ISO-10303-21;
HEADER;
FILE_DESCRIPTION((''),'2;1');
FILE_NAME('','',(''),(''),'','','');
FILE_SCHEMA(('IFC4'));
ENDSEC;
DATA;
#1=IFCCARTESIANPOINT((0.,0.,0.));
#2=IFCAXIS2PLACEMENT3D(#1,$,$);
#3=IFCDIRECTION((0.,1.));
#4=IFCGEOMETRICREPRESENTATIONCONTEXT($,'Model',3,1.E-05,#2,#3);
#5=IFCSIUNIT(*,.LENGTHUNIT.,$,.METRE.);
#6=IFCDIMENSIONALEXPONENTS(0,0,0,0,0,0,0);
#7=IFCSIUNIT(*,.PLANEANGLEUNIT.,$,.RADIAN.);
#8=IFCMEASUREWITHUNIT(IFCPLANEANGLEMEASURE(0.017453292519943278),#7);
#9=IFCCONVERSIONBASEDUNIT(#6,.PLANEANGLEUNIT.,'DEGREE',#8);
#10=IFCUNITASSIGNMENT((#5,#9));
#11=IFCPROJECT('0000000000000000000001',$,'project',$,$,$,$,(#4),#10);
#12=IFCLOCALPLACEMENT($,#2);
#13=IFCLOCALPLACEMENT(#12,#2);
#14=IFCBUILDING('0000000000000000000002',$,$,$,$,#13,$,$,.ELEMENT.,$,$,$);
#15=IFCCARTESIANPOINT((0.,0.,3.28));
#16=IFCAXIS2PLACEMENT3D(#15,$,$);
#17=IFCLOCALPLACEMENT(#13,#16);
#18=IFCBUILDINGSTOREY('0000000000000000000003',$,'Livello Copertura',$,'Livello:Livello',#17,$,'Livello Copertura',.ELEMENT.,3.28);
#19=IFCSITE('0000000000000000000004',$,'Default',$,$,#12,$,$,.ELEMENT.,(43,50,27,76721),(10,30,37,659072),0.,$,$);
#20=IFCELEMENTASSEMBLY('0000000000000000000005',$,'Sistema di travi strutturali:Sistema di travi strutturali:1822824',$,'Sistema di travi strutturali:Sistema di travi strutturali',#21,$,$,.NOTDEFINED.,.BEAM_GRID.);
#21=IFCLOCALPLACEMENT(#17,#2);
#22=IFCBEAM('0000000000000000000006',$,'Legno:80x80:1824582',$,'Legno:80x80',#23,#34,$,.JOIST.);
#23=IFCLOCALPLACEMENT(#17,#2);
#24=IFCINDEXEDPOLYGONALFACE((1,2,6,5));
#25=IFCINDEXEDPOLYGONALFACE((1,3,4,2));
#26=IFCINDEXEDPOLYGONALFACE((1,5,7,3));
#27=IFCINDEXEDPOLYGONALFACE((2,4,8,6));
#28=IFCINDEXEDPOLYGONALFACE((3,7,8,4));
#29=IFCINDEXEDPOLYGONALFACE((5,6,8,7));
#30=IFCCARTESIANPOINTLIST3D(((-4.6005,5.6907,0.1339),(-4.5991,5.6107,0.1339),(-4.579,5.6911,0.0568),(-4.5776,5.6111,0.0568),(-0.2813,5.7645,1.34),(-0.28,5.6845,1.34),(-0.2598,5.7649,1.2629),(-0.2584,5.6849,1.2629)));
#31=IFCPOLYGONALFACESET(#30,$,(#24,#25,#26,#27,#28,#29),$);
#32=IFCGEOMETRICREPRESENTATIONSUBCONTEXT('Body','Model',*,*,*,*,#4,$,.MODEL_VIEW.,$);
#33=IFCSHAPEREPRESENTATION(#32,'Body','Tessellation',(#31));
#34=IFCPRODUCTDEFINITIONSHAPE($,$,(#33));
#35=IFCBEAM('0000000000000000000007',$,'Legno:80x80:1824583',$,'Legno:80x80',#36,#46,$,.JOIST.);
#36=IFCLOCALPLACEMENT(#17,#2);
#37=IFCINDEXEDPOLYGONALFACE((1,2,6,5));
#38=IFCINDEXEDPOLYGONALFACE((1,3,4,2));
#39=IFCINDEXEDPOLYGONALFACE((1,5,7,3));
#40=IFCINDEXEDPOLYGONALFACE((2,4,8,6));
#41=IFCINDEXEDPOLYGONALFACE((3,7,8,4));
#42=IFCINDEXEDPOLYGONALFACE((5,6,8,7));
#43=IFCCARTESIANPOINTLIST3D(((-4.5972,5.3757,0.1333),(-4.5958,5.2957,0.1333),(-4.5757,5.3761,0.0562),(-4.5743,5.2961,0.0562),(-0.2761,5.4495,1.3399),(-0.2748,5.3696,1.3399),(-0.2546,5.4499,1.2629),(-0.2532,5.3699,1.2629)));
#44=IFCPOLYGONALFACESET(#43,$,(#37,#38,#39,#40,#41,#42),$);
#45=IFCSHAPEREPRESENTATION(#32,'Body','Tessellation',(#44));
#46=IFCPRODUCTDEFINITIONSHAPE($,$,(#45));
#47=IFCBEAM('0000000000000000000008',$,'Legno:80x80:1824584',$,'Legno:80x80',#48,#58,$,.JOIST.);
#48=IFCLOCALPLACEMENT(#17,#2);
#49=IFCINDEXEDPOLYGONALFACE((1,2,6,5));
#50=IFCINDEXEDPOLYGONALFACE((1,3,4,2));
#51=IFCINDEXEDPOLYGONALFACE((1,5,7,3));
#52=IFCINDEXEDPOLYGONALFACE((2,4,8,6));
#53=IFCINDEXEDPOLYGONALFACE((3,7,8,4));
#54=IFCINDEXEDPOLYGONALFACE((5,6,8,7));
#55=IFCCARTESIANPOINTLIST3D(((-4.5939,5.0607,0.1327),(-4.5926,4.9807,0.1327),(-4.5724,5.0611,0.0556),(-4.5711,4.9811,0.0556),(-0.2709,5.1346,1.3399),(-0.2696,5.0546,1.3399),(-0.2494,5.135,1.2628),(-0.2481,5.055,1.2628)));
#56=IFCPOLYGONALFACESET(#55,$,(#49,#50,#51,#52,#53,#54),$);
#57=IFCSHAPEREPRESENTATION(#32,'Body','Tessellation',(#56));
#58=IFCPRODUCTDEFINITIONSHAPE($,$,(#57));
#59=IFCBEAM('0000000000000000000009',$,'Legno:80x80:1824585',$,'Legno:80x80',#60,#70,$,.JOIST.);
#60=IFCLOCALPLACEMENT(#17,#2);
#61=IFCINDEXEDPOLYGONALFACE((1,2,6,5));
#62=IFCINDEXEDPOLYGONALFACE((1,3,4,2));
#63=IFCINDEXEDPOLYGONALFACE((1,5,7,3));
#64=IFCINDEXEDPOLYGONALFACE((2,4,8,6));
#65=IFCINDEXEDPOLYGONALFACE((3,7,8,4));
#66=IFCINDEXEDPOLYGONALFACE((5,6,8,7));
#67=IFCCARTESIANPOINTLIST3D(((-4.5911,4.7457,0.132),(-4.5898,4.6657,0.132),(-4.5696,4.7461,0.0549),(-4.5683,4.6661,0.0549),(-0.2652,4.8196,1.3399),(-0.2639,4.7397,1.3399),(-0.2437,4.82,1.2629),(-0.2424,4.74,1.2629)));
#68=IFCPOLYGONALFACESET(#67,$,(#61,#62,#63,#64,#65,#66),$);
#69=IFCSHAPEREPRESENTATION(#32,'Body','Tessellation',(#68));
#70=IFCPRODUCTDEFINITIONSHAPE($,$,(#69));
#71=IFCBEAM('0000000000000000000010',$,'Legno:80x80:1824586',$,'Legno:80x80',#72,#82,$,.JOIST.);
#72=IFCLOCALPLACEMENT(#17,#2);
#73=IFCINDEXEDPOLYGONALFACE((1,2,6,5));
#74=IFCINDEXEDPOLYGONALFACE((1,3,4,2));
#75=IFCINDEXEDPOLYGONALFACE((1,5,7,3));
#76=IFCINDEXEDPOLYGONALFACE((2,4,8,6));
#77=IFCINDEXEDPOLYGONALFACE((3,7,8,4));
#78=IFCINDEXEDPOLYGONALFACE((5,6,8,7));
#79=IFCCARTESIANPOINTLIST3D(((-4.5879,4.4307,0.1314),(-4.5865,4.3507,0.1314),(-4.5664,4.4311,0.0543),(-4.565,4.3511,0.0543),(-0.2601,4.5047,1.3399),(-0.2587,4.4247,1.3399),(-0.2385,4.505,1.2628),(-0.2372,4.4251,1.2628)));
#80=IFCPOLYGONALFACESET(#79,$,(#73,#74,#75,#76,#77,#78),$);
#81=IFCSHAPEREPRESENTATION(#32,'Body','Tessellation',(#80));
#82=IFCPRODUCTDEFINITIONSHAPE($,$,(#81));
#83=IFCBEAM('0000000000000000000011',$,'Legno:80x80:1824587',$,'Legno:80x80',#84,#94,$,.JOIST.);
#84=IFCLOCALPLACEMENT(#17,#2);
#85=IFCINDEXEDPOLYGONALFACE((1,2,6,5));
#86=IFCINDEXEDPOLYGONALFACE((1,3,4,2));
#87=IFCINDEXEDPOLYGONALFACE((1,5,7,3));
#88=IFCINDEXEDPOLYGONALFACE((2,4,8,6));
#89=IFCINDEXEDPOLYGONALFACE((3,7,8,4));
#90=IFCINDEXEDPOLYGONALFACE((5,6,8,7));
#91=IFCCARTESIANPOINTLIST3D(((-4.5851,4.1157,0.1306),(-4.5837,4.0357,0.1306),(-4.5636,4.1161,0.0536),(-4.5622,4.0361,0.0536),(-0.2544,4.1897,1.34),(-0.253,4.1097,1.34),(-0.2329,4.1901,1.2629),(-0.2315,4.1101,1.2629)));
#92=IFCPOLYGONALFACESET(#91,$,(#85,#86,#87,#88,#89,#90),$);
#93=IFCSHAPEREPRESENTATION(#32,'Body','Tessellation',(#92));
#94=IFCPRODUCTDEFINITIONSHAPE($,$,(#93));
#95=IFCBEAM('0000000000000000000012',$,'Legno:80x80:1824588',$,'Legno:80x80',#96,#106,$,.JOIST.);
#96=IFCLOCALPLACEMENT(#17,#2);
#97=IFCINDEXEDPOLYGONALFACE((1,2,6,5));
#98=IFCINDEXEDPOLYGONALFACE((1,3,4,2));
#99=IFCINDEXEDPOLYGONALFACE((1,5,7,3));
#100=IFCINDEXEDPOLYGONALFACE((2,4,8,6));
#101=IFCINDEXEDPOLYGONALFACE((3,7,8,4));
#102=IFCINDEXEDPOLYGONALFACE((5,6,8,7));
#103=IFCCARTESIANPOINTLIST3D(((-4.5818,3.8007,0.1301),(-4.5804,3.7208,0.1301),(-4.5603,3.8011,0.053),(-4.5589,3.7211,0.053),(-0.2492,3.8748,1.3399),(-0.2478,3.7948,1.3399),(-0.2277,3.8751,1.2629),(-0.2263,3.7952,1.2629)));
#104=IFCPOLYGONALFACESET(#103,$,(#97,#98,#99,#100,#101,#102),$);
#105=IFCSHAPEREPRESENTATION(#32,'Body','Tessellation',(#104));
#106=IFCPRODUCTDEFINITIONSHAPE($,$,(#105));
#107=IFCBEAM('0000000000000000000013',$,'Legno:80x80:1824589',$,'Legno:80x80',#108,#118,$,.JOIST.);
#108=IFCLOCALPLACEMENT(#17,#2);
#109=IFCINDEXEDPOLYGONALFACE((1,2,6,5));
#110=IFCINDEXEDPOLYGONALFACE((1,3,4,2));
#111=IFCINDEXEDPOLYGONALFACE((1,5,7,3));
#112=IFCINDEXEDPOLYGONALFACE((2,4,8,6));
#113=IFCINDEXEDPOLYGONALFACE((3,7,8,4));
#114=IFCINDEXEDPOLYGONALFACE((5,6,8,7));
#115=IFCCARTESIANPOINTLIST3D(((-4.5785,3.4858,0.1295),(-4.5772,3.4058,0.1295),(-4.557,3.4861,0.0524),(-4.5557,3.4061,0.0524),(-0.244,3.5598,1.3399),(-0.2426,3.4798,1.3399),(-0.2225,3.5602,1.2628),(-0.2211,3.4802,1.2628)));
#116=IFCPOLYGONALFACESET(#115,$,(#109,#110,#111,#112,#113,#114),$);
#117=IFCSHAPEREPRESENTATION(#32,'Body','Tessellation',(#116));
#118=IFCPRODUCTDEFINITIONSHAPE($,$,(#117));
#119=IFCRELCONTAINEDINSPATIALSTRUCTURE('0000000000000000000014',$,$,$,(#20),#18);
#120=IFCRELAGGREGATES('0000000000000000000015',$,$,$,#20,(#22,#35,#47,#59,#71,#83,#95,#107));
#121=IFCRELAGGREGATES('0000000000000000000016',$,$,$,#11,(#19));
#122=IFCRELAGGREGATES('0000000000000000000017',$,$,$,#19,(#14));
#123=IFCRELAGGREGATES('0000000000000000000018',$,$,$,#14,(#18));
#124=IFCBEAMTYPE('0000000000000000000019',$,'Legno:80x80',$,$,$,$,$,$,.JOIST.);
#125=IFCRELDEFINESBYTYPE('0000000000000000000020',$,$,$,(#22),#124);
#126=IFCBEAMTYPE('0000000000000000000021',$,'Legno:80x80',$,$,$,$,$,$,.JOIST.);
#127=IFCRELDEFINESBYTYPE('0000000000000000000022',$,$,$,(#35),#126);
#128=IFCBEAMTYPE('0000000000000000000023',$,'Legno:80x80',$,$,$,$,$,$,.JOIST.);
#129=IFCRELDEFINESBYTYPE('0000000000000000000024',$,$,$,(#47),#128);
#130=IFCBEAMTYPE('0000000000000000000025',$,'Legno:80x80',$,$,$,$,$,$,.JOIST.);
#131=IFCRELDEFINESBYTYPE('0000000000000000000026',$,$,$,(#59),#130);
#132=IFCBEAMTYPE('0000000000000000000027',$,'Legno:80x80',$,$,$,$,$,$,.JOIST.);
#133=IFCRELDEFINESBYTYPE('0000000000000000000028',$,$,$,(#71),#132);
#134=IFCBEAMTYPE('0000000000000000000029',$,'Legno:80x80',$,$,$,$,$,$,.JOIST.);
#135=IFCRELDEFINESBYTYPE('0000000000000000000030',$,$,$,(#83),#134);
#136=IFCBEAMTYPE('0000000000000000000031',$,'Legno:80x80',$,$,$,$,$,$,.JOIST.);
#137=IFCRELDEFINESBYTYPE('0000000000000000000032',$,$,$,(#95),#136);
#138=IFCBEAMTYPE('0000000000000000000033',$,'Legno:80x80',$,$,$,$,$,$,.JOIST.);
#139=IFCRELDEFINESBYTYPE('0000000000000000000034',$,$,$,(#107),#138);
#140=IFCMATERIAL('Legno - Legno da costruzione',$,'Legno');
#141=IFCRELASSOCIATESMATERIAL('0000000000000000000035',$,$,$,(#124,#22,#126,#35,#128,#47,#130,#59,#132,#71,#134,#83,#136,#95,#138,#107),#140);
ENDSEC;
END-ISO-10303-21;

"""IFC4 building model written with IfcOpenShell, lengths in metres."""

from ifc_helpers import new_model, entity, si_unit, converted_unit, direction, frame, origin, place, context, subcontext, project, spatial, indexed_curve, outline, extrude, source, transform, mapped, material, type_object, type_shapes, element, aggregate, save


model = new_model("IFC4")

# Units and contexts
model_context = context("Model", 3, precision=1e-05, world=origin(), true_north=direction((0.0, 1.0)))
body_context = subcontext(model_context, "Body", "Model", "MODEL_VIEW")
ifc_project = project(units=[si_unit("LENGTHUNIT", "METRE"), converted_unit("PLANEANGLEUNIT", "DEGREE", entity("IfcPlaneAngleMeasure", 0.017453292519943278), si_unit("PLANEANGLEUNIT", "RADIAN"), dimensions=[0, 0, 0, 0, 0, 0, 0])], contexts=[model_context])

# Site, building, storey
site_placement = place(None, origin())
site = spatial("IfcSite", under=ifc_project, at=site_placement, Name="Default", CompositionType="ELEMENT", RefLatitude=(43, 50, 27, 76721), RefLongitude=(10, 30, 37, 659072), RefElevation=0.0)
building_placement = place(site_placement, origin())
building = spatial("IfcBuilding", under=site, at=building_placement, CompositionType="ELEMENT")
storey_placement = place(building_placement, frame((0.0, 0.0, 3.28)))
storey = spatial("IfcBuildingStorey", under=building, at=storey_placement, Name="Livello Copertura", ObjectType="Livello:Livello", LongName="Livello Copertura", CompositionType="ELEMENT", Elevation=3.28)

# Shared definitions
ifc_material_1 = material(Name="Legno - Legno da costruzione", Category="Legno")

# Element assembly, beams
assembly_1_placement = place(storey_placement, origin())
assembly_1 = element("IfcElementAssembly", 1, at=assembly_1_placement, inside=storey, Name="Sistema di travi strutturali:Sistema di travi strutturali:1822824", ObjectType="Sistema di travi strutturali:Sistema di travi strutturali", AssemblyPlace="NOTDEFINED", PredefinedType="BEAM_GRID")
beam_type_1 = type_object("IfcBeamType", Name="Legno:80x80", PredefinedType="JOIST", material=ifc_material_1)
shared_shape_1 = source(origin(), body_context, "Body", "SweptSolid", [
    extrude(outline(indexed_curve([(-2.2425, -0.04), (2.2425, -0.04), (2.2425, 0.04), (-2.2425, 0.04), (-2.2425, -0.04)], self_intersect=False)), frame((0.0, 0.0, -0.04), z_axis=(0.0, 0.0, 1.0), x_axis=(-1.0, 0.0, 0.0)), (0.0, 0.0, 1.0), 0.08),
])
type_shapes(beam_type_1, [shared_shape_1])
beam_1_placement = place(assembly_1_placement, frame((-2.4295, 5.6878, 0.6984), z_axis=(-0.268881, -0.004594, 0.963163), x_axis=(0.963022, 0.016456, 0.26892)))
beam_1 = element("IfcBeam", 2, at=beam_1_placement, type_object=beam_type_1, material=ifc_material_1, Name="Legno:80x80:1824582", ObjectType="Legno:80x80", PredefinedType="JOIST", context=body_context, shape_type="MappedRepresentation", body=[
    mapped(shared_shape_1, transform((0.0, 0.0, 0.0), scale=1.0)),
])
beam_type_2 = type_object("IfcBeamType", Name="Legno:80x80", PredefinedType="JOIST", material=ifc_material_1)
shared_shape_2 = source(origin(), body_context, "Body", "SweptSolid", [
    extrude(outline(indexed_curve([(-2.2435, -0.04), (2.2435, -0.04), (2.2435, 0.04), (-2.2435, 0.04), (-2.2435, -0.04)], self_intersect=False)), frame((0.0, 0.0, -0.04), z_axis=(0.0, 0.0, 1.0), x_axis=(-1.0, 0.0, 0.0)), (0.0, 0.0, 1.0), 0.08),
])
type_shapes(beam_type_2, [shared_shape_2])
beam_2_placement = place(assembly_1_placement, frame((-2.4252, 5.3728, 0.6981), z_axis=(-0.268881, -0.004594, 0.963163), x_axis=(0.963022, 0.016456, 0.26892)))
beam_2 = element("IfcBeam", 3, at=beam_2_placement, type_object=beam_type_2, material=ifc_material_1, Name="Legno:80x80:1824583", ObjectType="Legno:80x80", PredefinedType="JOIST", context=body_context, shape_type="MappedRepresentation", body=[
    mapped(shared_shape_2, transform((0.0, 0.0, 0.0), scale=1.0)),
])
beam_type_3 = type_object("IfcBeamType", Name="Legno:80x80", PredefinedType="JOIST", material=ifc_material_1)
shared_shape_3 = source(origin(), body_context, "Body", "SweptSolid", [
    extrude(outline(indexed_curve([(-2.2445, -0.04), (2.2445, -0.04), (2.2445, 0.04), (-2.2445, 0.04), (-2.2445, -0.04)], self_intersect=False)), frame((0.0, 0.0, -0.04), z_axis=(0.0, 0.0, 1.0), x_axis=(-1.0, 0.0, 0.0)), (0.0, 0.0, 1.0), 0.08),
])
type_shapes(beam_type_3, [shared_shape_3])
beam_3_placement = place(assembly_1_placement, frame((-2.421, 5.0578, 0.6977), z_axis=(-0.268881, -0.004594, 0.963163), x_axis=(0.963022, 0.016456, 0.26892)))
beam_3 = element("IfcBeam", 4, at=beam_3_placement, type_object=beam_type_3, material=ifc_material_1, Name="Legno:80x80:1824584", ObjectType="Legno:80x80", PredefinedType="JOIST", context=body_context, shape_type="MappedRepresentation", body=[
    mapped(shared_shape_3, transform((0.0, 0.0, 0.0), scale=1.0)),
])
beam_type_4 = type_object("IfcBeamType", Name="Legno:80x80", PredefinedType="JOIST", material=ifc_material_1)
shared_shape_4 = source(origin(), body_context, "Body", "SweptSolid", [
    extrude(outline(indexed_curve([(-2.246, -0.04), (2.246, -0.04), (2.246, 0.04), (-2.246, 0.04), (-2.246, -0.04)], self_intersect=False)), frame((0.0, 0.0, -0.04), z_axis=(0.0, 0.0, 1.0), x_axis=(-1.0, 0.0, 0.0)), (0.0, 0.0, 1.0), 0.08),
])
type_shapes(beam_type_4, [shared_shape_4])
beam_4_placement = place(assembly_1_placement, frame((-2.4168, 4.7429, 0.6974), z_axis=(-0.268881, -0.004594, 0.963163), x_axis=(0.963022, 0.016456, 0.26892)))
beam_4 = element("IfcBeam", 5, at=beam_4_placement, type_object=beam_type_4, material=ifc_material_1, Name="Legno:80x80:1824585", ObjectType="Legno:80x80", PredefinedType="JOIST", context=body_context, shape_type="MappedRepresentation", body=[
    mapped(shared_shape_4, transform((0.0, 0.0, 0.0), scale=1.0)),
])
beam_type_5 = type_object("IfcBeamType", Name="Legno:80x80", PredefinedType="JOIST", material=ifc_material_1)
shared_shape_5 = source(origin(), body_context, "Body", "SweptSolid", [
    extrude(outline(indexed_curve([(-2.247, -0.04), (2.247, -0.04), (2.247, 0.04), (-2.247, 0.04), (-2.247, -0.04)], self_intersect=False)), frame((0.0, 0.0, -0.04), z_axis=(0.0, 0.0, 1.0), x_axis=(-1.0, 0.0, 0.0)), (0.0, 0.0, 1.0), 0.08),
])
type_shapes(beam_type_5, [shared_shape_5])
beam_5_placement = place(assembly_1_placement, frame((-2.4125, 4.4279, 0.6971), z_axis=(-0.268881, -0.004594, 0.963163), x_axis=(0.963022, 0.016456, 0.26892)))
beam_5 = element("IfcBeam", 6, at=beam_5_placement, type_object=beam_type_5, material=ifc_material_1, Name="Legno:80x80:1824586", ObjectType="Legno:80x80", PredefinedType="JOIST", context=body_context, shape_type="MappedRepresentation", body=[
    mapped(shared_shape_5, transform((0.0, 0.0, 0.0), scale=1.0)),
])
beam_type_6 = type_object("IfcBeamType", Name="Legno:80x80", PredefinedType="JOIST", material=ifc_material_1)
shared_shape_6 = source(origin(), body_context, "Body", "SweptSolid", [
    extrude(outline(indexed_curve([(-2.2485, -0.04), (2.2485, -0.04), (2.2485, 0.04), (-2.2485, 0.04), (-2.2485, -0.04)], self_intersect=False)), frame((0.0, 0.0, -0.04), z_axis=(0.0, 0.0, 1.0), x_axis=(-1.0, 0.0, 0.0)), (0.0, 0.0, 1.0), 0.08),
])
type_shapes(beam_type_6, [shared_shape_6])
beam_6_placement = place(assembly_1_placement, frame((-2.4083, 4.1129, 0.6968), z_axis=(-0.268881, -0.004594, 0.963163), x_axis=(0.963022, 0.016456, 0.26892)))
beam_6 = element("IfcBeam", 7, at=beam_6_placement, type_object=beam_type_6, material=ifc_material_1, Name="Legno:80x80:1824587", ObjectType="Legno:80x80", PredefinedType="JOIST", context=body_context, shape_type="MappedRepresentation", body=[
    mapped(shared_shape_6, transform((0.0, 0.0, 0.0), scale=1.0)),
])
beam_type_7 = type_object("IfcBeamType", Name="Legno:80x80", PredefinedType="JOIST", material=ifc_material_1)
shared_shape_7 = source(origin(), body_context, "Body", "SweptSolid", [
    extrude(outline(indexed_curve([(-2.2495, -0.04), (2.2495, -0.04), (2.2495, 0.04), (-2.2495, 0.04), (-2.2495, -0.04)], self_intersect=False)), frame((0.0, 0.0, -0.04), z_axis=(0.0, 0.0, 1.0), x_axis=(-1.0, 0.0, 0.0)), (0.0, 0.0, 1.0), 0.08),
])
type_shapes(beam_type_7, [shared_shape_7])
beam_7_placement = place(assembly_1_placement, frame((-2.4041, 3.7979, 0.6965), z_axis=(-0.268881, -0.004594, 0.963163), x_axis=(0.963022, 0.016456, 0.26892)))
beam_7 = element("IfcBeam", 8, at=beam_7_placement, type_object=beam_type_7, material=ifc_material_1, Name="Legno:80x80:1824588", ObjectType="Legno:80x80", PredefinedType="JOIST", context=body_context, shape_type="MappedRepresentation", body=[
    mapped(shared_shape_7, transform((0.0, 0.0, 0.0), scale=1.0)),
])
beam_type_8 = type_object("IfcBeamType", Name="Legno:80x80", PredefinedType="JOIST", material=ifc_material_1)
shared_shape_8 = source(origin(), body_context, "Body", "SweptSolid", [
    extrude(outline(indexed_curve([(-2.2505, -0.04), (2.2505, -0.04), (2.2505, 0.04), (-2.2505, 0.04), (-2.2505, -0.04)], self_intersect=False)), frame((0.0, 0.0, -0.04), z_axis=(0.0, 0.0, 1.0), x_axis=(-1.0, 0.0, 0.0)), (0.0, 0.0, 1.0), 0.08),
])
type_shapes(beam_type_8, [shared_shape_8])
beam_8_placement = place(assembly_1_placement, frame((-2.3998, 3.483, 0.6961), z_axis=(-0.268881, -0.004594, 0.963163), x_axis=(0.963022, 0.016456, 0.26892)))
beam_8 = element("IfcBeam", 9, at=beam_8_placement, type_object=beam_type_8, material=ifc_material_1, Name="Legno:80x80:1824589", ObjectType="Legno:80x80", PredefinedType="JOIST", context=body_context, shape_type="MappedRepresentation", body=[
    mapped(shared_shape_8, transform((0.0, 0.0, 0.0), scale=1.0)),
])
aggregate(assembly_1, [beam_1, beam_2, beam_3, beam_4, beam_5, beam_6, beam_7, beam_8])

save(model, "model.ifc")
